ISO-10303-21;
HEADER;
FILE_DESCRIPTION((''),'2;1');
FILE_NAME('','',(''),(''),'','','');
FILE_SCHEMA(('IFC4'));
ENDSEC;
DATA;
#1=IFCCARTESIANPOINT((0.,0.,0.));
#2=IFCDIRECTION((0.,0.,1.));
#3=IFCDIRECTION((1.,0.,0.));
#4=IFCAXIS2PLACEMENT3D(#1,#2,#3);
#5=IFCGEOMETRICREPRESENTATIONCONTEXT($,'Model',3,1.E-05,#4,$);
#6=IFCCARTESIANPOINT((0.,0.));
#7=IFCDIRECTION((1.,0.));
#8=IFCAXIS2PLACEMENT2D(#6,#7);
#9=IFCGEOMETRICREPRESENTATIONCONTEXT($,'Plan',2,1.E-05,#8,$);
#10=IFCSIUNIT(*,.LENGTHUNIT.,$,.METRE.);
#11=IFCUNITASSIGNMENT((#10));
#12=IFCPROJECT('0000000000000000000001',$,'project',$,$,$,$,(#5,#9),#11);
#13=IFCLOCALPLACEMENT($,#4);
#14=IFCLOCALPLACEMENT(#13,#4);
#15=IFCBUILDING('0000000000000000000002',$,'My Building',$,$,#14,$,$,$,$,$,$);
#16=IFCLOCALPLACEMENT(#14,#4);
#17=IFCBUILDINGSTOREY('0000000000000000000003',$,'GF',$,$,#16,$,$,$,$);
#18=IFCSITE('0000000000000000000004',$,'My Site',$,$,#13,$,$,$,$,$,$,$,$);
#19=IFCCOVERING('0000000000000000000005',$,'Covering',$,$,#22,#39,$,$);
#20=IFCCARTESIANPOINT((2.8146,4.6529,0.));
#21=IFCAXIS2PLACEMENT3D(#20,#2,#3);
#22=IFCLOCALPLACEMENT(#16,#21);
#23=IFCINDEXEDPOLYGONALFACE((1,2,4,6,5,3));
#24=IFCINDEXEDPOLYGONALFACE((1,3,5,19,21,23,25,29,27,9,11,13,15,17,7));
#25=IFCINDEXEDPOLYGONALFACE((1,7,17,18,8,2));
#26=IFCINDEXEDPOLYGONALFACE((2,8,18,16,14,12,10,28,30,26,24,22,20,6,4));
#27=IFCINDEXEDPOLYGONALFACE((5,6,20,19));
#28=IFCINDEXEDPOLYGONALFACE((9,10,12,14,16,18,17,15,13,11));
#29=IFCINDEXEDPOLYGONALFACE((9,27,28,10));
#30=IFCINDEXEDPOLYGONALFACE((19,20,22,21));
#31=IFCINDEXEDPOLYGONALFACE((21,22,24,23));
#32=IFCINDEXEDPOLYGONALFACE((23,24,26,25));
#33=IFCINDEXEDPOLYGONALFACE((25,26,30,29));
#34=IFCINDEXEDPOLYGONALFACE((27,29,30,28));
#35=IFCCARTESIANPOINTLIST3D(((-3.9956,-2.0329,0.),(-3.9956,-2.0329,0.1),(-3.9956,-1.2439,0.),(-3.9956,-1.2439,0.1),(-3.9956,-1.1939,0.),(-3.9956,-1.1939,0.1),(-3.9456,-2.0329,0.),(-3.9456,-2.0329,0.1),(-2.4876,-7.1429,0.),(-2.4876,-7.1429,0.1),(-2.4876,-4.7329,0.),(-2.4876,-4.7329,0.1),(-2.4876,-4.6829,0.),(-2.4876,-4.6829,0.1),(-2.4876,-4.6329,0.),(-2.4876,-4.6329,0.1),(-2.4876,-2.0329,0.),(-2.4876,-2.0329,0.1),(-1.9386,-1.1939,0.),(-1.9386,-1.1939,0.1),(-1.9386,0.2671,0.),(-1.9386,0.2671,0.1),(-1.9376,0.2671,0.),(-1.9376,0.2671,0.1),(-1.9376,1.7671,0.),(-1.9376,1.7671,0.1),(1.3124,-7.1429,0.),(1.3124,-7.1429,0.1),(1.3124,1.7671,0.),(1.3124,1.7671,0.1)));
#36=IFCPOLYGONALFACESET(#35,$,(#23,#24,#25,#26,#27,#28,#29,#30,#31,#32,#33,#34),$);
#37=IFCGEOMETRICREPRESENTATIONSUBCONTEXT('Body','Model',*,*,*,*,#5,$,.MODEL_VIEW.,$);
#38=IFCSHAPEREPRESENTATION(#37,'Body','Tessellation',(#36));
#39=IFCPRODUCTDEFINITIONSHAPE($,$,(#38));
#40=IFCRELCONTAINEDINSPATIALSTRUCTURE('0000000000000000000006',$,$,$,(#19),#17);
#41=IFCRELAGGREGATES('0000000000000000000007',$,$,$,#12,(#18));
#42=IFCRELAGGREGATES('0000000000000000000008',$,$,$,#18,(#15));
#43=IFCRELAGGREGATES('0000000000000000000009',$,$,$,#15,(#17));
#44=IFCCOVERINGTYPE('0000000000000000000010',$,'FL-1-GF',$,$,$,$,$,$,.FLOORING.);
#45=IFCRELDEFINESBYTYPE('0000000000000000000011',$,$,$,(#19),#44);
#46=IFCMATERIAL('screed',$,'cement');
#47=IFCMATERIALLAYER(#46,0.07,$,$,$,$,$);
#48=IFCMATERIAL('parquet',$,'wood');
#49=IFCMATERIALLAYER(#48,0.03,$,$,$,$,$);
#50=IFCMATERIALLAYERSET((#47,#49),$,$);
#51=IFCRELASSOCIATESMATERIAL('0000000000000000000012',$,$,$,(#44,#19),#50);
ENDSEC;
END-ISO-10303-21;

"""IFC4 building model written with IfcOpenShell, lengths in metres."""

from ifc_helpers import new_model, si_unit, frame, origin_with_axes, origin_2d_with_axis, place, context, subcontext, project, spatial, line, indexed_curve, outline, extrude, material, layer, layer_set, layer_usage, type_object, element, save


model = new_model("IFC4")

# Units and contexts
model_context = context("Model", 3, precision=1e-05, world=origin_with_axes())
plan_context = context("Plan", 2, precision=1e-05, world=origin_2d_with_axis())
body_context_1 = subcontext(model_context, "Body", "Model", "MODEL_VIEW")
ifc_project = project(units=[si_unit("LENGTHUNIT", "METRE")], contexts=[model_context, plan_context])

# Site, building, storey
site_placement = place(None, origin_with_axes())
site = spatial("IfcSite", under=ifc_project, at=site_placement, Name="My Site")
building_placement = place(site_placement, origin_with_axes())
building = spatial("IfcBuilding", under=site, at=building_placement, Name="My Building")
storey_placement = place(building_placement, origin_with_axes())
storey = spatial("IfcBuildingStorey", under=building, at=storey_placement, Name="GF")

# Covering
ifc_material_1 = material(Name="screed", Category="cement")
ifc_layer_1 = layer(ifc_material_1, 0.07)
ifc_material_2 = material(Name="parquet", Category="wood")
ifc_layer_2 = layer(ifc_material_2, 0.03)
ifc_layer_set_1 = layer_set([ifc_layer_1, ifc_layer_2])
ifc_layer_usage_1 = layer_usage(ifc_layer_set_1, "AXIS3", "POSITIVE", 0.0)
covering_type = type_object("IfcCoveringType", Name="FL-1-GF", PredefinedType="FLOORING", material=ifc_layer_set_1)
covering_placement = place(storey_placement, frame((2.8146, 4.6529, 0.0), z_axis=(0.0, 0.0, 1.0), x_axis=(1.0, 0.0, 0.0)))
element("IfcCovering", 1, at=covering_placement, inside=storey, type_object=covering_type, material=ifc_layer_usage_1, Name="Covering", context=body_context_1, shape_type="SweptSolid", body=[
    extrude(outline(indexed_curve([(-1.9376, 1.7671), (1.3124, 1.7671), (1.3124, -7.1429), (-2.4876, -7.1429), (-2.4876, -4.7329), (-2.4876, -4.6829), (-2.4876, -4.6829), (-2.4876, -4.6329), (-2.4876, -2.0329), (-3.9456, -2.0329), (-3.9956, -2.0329), (-3.9956, -1.2439), (-3.9956, -1.1939), (-1.9386, -1.1939), (-1.9386, 0.2671), (-1.9376, 0.2671)], segments=[line(1, 2, 3, 4, 5, 6, 7, 8, 9, 10, 11, 12, 13, 14, 15, 16, 1)])), origin_with_axes(), (0.0, 0.0, 1.0), 0.1),
])

save(model, "model.ifc")
